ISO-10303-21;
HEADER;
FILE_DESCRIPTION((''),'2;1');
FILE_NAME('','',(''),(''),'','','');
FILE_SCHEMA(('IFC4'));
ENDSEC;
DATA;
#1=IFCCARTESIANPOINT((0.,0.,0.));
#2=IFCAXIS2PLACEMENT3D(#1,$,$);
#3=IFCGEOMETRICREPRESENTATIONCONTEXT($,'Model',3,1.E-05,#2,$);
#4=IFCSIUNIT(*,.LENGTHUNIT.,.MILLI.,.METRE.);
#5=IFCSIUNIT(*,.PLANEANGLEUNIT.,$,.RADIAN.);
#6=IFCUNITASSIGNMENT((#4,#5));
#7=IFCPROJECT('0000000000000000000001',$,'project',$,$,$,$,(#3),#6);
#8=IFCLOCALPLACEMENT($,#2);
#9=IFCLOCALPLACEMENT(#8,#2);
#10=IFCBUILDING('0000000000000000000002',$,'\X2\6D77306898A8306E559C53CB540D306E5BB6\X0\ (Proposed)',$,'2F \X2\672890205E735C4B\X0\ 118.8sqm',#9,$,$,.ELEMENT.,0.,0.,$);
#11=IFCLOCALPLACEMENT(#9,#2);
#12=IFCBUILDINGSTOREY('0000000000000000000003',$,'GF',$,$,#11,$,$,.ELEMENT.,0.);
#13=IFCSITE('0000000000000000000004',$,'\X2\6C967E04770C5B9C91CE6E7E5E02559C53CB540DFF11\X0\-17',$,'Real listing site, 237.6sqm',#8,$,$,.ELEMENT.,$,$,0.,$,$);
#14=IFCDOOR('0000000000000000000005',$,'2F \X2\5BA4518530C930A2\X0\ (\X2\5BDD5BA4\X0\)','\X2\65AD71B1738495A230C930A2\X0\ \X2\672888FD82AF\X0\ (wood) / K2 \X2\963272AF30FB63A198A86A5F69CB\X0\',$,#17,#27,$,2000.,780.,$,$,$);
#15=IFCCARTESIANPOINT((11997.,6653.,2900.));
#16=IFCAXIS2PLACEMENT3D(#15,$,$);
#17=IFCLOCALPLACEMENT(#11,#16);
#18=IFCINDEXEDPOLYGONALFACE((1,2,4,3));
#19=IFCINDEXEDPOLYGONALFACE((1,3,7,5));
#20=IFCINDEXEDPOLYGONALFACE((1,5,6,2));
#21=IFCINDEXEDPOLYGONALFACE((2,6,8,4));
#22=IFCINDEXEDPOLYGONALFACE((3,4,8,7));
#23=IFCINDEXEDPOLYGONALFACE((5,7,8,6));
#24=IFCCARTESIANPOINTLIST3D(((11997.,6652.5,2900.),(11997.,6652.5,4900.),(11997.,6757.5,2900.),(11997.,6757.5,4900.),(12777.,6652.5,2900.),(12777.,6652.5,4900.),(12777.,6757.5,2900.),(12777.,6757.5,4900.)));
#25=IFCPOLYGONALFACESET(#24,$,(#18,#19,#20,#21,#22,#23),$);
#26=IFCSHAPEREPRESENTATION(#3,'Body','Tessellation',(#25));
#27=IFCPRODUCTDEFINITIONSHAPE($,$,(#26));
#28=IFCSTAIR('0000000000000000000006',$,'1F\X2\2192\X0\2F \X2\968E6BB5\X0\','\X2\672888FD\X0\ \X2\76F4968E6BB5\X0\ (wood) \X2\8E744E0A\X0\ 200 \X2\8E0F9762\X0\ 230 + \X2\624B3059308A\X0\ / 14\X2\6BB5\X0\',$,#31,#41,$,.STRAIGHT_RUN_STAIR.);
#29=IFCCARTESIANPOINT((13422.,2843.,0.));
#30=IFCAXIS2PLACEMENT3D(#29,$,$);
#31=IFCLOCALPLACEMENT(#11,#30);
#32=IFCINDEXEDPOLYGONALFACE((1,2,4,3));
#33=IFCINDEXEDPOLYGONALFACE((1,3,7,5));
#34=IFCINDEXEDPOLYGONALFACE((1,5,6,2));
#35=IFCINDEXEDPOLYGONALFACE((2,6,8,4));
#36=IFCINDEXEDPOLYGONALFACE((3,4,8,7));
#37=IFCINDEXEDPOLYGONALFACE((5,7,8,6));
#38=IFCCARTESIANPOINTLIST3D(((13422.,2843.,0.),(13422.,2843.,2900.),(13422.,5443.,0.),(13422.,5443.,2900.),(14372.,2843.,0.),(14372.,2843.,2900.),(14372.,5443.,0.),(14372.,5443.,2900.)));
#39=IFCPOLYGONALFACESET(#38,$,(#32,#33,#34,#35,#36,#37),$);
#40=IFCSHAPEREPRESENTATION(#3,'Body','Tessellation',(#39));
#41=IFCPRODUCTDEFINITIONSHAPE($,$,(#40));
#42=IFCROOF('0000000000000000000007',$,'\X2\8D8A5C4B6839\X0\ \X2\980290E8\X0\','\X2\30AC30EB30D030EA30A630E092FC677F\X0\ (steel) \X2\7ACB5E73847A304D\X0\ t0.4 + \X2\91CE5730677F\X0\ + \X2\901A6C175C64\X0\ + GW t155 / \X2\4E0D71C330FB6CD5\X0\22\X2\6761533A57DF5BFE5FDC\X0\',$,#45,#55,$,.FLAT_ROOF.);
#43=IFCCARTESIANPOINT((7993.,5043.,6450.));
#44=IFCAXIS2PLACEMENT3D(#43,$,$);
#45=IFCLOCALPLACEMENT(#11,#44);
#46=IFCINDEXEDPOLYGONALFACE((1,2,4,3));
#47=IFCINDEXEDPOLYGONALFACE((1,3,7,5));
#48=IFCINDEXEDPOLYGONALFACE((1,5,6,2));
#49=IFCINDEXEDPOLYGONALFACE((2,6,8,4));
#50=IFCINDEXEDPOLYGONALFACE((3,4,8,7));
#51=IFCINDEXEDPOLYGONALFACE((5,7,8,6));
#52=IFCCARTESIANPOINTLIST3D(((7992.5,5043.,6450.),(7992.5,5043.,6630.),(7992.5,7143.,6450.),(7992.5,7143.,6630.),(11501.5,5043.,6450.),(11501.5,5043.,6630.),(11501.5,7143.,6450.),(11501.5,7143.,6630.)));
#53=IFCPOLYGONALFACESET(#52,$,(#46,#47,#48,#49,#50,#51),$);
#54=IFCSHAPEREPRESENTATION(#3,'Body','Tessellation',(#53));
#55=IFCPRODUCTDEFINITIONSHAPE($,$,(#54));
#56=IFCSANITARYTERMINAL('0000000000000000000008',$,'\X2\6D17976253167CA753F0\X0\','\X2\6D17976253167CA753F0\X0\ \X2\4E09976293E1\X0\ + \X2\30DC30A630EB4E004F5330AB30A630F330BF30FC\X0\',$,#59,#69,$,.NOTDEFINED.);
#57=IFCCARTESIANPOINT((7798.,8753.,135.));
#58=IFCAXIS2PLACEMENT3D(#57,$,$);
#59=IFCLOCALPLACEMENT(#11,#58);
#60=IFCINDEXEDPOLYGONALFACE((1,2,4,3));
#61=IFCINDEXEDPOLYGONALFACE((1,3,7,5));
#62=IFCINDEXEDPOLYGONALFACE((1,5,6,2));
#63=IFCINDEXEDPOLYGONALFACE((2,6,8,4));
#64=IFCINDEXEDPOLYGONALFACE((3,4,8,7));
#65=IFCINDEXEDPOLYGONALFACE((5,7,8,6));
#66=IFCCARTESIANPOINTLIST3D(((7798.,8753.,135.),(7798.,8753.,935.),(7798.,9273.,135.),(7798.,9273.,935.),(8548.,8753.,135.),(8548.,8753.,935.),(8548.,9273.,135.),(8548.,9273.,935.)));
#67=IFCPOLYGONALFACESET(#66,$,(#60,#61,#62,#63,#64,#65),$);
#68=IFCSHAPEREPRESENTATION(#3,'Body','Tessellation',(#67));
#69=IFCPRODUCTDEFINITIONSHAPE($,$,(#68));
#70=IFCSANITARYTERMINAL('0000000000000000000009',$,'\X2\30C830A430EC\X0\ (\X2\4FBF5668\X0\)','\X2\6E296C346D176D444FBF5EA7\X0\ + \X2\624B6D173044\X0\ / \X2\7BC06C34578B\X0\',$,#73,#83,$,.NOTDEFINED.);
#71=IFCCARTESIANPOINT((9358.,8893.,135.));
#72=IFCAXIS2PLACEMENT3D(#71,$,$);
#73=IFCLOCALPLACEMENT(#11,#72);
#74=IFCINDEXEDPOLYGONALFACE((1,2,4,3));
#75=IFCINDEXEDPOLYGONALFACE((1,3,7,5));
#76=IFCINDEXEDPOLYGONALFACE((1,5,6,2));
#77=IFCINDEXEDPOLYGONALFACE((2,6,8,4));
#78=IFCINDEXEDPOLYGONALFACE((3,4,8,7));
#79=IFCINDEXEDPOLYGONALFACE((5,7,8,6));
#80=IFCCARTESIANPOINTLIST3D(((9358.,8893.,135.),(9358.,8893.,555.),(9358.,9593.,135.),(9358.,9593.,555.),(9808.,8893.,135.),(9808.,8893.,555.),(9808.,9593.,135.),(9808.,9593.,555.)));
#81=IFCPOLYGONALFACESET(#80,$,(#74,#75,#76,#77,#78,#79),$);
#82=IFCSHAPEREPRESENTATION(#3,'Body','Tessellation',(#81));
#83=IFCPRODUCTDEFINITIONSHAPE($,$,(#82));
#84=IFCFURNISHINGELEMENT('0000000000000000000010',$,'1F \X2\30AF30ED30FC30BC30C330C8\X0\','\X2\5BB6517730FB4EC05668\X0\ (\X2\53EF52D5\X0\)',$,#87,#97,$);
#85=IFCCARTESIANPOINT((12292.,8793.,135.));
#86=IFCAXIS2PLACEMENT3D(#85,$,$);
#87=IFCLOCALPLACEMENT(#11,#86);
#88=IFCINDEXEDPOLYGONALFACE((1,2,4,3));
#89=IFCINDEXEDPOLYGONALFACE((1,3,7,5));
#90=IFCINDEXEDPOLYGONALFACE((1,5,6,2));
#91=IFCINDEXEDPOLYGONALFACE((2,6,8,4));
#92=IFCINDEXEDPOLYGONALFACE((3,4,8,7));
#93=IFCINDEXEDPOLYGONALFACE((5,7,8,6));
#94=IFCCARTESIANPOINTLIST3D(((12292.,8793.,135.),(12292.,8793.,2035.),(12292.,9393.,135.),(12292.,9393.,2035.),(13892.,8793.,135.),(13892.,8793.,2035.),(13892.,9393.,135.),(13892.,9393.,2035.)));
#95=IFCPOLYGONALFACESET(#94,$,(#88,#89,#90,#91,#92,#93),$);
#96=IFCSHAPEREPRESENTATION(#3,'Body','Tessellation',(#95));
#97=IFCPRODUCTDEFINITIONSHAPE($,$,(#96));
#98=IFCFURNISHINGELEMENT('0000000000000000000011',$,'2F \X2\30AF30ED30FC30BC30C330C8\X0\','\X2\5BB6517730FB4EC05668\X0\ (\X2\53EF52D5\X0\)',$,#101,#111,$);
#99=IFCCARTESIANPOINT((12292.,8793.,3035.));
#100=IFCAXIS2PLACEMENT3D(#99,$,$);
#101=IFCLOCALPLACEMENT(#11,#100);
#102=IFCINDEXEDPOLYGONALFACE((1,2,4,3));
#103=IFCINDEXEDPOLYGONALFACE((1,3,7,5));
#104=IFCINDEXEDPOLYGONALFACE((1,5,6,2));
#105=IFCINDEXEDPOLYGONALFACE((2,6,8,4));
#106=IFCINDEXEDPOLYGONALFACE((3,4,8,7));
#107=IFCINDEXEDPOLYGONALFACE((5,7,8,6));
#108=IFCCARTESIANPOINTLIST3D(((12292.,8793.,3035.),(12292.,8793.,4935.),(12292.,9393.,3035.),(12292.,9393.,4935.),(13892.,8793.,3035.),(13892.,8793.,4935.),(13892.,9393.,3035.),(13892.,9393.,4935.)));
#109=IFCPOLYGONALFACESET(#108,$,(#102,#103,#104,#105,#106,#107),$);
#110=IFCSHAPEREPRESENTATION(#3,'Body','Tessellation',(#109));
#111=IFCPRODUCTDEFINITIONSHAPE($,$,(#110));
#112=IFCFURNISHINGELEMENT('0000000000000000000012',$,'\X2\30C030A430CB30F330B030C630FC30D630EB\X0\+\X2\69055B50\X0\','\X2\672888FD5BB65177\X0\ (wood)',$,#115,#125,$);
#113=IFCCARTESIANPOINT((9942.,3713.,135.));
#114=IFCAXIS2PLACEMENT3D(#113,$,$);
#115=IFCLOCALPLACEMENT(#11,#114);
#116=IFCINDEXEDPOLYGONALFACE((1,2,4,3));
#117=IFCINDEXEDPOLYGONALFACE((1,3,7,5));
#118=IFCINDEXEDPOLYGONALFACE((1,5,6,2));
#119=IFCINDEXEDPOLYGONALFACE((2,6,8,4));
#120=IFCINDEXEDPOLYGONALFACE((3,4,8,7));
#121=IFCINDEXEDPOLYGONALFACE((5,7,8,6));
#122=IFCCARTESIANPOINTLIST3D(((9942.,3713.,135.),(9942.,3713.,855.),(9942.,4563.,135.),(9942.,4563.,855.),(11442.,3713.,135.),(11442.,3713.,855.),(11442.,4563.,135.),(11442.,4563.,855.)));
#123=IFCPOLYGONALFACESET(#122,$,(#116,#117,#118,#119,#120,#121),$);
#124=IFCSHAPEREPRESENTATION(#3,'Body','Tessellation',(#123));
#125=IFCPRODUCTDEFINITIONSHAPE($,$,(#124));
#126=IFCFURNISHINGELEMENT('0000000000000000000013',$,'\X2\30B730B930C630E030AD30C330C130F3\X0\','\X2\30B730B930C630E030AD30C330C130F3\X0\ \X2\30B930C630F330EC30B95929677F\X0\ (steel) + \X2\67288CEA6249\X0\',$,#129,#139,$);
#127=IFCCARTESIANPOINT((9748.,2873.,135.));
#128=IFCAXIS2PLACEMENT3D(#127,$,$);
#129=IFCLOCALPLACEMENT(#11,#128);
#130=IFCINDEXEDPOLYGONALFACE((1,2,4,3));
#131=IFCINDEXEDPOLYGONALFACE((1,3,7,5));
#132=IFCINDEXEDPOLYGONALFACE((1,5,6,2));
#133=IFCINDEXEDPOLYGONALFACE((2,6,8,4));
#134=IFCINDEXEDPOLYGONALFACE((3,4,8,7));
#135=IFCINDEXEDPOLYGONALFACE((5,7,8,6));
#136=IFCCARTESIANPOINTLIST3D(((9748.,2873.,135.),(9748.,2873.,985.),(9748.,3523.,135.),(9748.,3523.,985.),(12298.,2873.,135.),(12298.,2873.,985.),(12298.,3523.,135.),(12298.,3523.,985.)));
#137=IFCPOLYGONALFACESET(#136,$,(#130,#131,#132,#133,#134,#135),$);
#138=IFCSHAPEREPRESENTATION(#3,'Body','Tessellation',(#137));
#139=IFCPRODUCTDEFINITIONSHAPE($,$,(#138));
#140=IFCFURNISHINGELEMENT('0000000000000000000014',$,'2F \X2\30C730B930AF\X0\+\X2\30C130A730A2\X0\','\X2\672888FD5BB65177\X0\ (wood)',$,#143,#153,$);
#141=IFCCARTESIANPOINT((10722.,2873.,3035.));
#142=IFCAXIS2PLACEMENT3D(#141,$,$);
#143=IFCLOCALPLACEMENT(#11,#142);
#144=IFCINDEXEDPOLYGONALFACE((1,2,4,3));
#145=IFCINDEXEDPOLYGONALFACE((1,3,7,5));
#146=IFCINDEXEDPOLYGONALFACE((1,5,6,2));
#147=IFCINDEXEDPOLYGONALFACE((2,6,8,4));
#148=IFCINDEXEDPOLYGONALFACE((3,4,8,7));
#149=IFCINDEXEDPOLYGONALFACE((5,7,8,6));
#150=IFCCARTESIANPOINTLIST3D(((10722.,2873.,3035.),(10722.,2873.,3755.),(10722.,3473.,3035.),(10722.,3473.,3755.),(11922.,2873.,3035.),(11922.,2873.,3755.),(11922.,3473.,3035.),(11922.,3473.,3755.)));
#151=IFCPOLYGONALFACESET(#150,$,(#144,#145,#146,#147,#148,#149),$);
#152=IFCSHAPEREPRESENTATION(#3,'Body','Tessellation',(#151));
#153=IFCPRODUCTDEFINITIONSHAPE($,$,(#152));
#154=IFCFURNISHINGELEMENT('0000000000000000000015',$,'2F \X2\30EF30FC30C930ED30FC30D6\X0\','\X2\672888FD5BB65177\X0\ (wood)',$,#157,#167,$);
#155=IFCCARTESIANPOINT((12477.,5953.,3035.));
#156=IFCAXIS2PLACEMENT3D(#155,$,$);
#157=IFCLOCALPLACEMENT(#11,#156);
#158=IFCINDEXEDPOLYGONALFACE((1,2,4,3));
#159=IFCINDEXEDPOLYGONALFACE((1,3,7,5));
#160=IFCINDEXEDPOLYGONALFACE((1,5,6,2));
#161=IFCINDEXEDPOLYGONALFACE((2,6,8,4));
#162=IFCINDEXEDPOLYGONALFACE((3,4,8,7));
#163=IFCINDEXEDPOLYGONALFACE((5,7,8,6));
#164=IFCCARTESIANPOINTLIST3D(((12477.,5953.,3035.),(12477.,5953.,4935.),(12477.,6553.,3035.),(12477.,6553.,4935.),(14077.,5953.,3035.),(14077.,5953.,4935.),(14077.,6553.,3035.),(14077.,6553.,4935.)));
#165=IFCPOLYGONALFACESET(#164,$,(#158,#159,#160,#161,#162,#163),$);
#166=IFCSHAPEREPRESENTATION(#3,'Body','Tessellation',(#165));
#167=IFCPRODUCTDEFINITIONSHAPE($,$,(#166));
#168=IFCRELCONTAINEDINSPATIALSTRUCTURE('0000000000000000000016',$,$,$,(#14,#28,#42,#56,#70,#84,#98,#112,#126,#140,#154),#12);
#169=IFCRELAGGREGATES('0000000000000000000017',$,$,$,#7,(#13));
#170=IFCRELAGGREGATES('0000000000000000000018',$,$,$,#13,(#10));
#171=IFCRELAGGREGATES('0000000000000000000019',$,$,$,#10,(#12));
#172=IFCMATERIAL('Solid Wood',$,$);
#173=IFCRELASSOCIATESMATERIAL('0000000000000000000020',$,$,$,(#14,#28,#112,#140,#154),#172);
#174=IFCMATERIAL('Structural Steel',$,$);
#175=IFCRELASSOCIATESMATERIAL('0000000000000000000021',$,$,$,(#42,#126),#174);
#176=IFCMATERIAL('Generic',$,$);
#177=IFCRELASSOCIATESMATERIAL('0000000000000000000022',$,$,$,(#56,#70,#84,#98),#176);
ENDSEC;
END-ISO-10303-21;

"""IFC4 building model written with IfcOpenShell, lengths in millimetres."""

from ifc_helpers import new_model, si_unit, frame, frame_2d, origin, place, context, project, spatial, rectangle, extrude, material, element, save


model = new_model("IFC4")

# Units and contexts
model_context = context("Model", 3, precision=1e-05, world=origin())
ifc_project = project(units=[si_unit("LENGTHUNIT", "METRE", prefix="MILLI"), si_unit("PLANEANGLEUNIT", "RADIAN")], contexts=[model_context])

# Site, building, storey
site_placement = place(None, origin())
site = spatial("IfcSite", under=ifc_project, at=site_placement, Name="沖縄県宜野湾市喜友名１-17", ObjectType="Real listing site, 237.6sqm", CompositionType="ELEMENT", RefElevation=0.0)
building_placement = place(site_placement, origin())
building = spatial("IfcBuilding", under=site, at=building_placement, Name="海と風の喜友名の家 (Proposed)", ObjectType="2F 木造平屋 118.8sqm", CompositionType="ELEMENT", ElevationOfRefHeight=0.0, ElevationOfTerrain=0.0)
storey_placement = place(building_placement, origin())
storey = spatial("IfcBuildingStorey", under=building, at=storey_placement, Name="GF", CompositionType="ELEMENT", Elevation=0.0)

# Shared definitions
ifc_material_1 = material(Name="Solid Wood")

# Door
door_1_placement = place(storey_placement, frame((11997.0, 6653.0, 2900.0)))
element("IfcDoor", 1, at=door_1_placement, inside=storey, material=ifc_material_1, Name="2F 室内ドア (寝室)", Description="断熱玄関ドア 木製芯 (wood) / K2 防犯・採風機構", OverallHeight=2000.0, OverallWidth=780.0, context=model_context, shape_type="SweptSolid", body=[
    extrude(rectangle(XDim=780.0, YDim=105.0, at=frame_2d((390.0, 52.0))), frame((11997.0, 6653.0, 2900.0)), (0.0, 0.0, 1.0), 2000.0),
])

# Stair
stair_placement = place(storey_placement, frame((13422.0, 2843.0, 0.0)))
element("IfcStair", 2, at=stair_placement, inside=storey, material=ifc_material_1, Name="1F→2F 階段", Description="木製 直階段 (wood) 蹴上 200 踏面 230 + 手すり / 14段", PredefinedType="STRAIGHT_RUN_STAIR", context=model_context, shape_type="SweptSolid", body=[
    extrude(rectangle(XDim=950.0, YDim=2600.0, at=frame_2d((475.0, 1300.0))), frame((13422.0, 2843.0, 0.0)), (0.0, 0.0, 1.0), 2900.0),
])

# Roof
ifc_material_2 = material(Name="Structural Steel")
roof_placement = place(storey_placement, frame((7993.0, 5043.0, 6450.0)))
element("IfcRoof", 3, at=roof_placement, inside=storey, material=ifc_material_2, Name="越屋根 頂部", Description="ガルバリウム鋼板 (steel) 立平葺き t0.4 + 野地板 + 通気層 + GW t155 / 不燃・法22条区域対応", PredefinedType="FLAT_ROOF", context=model_context, shape_type="SweptSolid", body=[
    extrude(rectangle(XDim=3509.0, YDim=2100.0, at=frame_2d((1754.0, 1050.0))), frame((7993.0, 5043.0, 6450.0)), (0.0, 0.0, 1.0), 180.0),
])

# Sanitary terminals
ifc_material_3 = material(Name="Generic")
sanitary_terminal_1_placement = place(storey_placement, frame((7798.0, 8753.0, 135.0)))
element("IfcSanitaryTerminal", 4, at=sanitary_terminal_1_placement, inside=storey, material=ifc_material_3, Name="洗面化粧台", Description="洗面化粧台 三面鏡 + ボウル一体カウンター", PredefinedType="NOTDEFINED", context=model_context, shape_type="SweptSolid", body=[
    extrude(rectangle(XDim=750.0, YDim=520.0, at=frame_2d((375.0, 260.0))), frame((7798.0, 8753.0, 135.0)), (0.0, 0.0, 1.0), 800.0),
])
sanitary_terminal_2_placement = place(storey_placement, frame((9358.0, 8893.0, 135.0)))
element("IfcSanitaryTerminal", 5, at=sanitary_terminal_2_placement, inside=storey, material=ifc_material_3, Name="トイレ (便器)", Description="温水洗浄便座 + 手洗い / 節水型", PredefinedType="NOTDEFINED", context=model_context, shape_type="SweptSolid", body=[
    extrude(rectangle(XDim=450.0, YDim=700.0, at=frame_2d((225.0, 350.0))), frame((9358.0, 8893.0, 135.0)), (0.0, 0.0, 1.0), 420.0),
])

# Furnishing elements
furnishing_1_placement = place(storey_placement, frame((12292.0, 8793.0, 135.0)))
element("IfcFurnishingElement", 6, at=furnishing_1_placement, inside=storey, material=ifc_material_3, Name="1F クローゼット", Description="家具・什器 (可動)", context=model_context, shape_type="SweptSolid", body=[
    extrude(rectangle(XDim=1600.0, YDim=600.0, at=frame_2d((800.0, 300.0))), frame((12292.0, 8793.0, 135.0)), (0.0, 0.0, 1.0), 1900.0),
])
furnishing_2_placement = place(storey_placement, frame((12292.0, 8793.0, 3035.0)))
element("IfcFurnishingElement", 7, at=furnishing_2_placement, inside=storey, material=ifc_material_3, Name="2F クローゼット", Description="家具・什器 (可動)", context=model_context, shape_type="SweptSolid", body=[
    extrude(rectangle(XDim=1600.0, YDim=600.0, at=frame_2d((800.0, 300.0))), frame((12292.0, 8793.0, 3035.0)), (0.0, 0.0, 1.0), 1900.0),
])
furnishing_3_placement = place(storey_placement, frame((9942.0, 3713.0, 135.0)))
element("IfcFurnishingElement", 8, at=furnishing_3_placement, inside=storey, material=ifc_material_1, Name="ダイニングテーブル+椅子", Description="木製家具 (wood)", context=model_context, shape_type="SweptSolid", body=[
    extrude(rectangle(XDim=1500.0, YDim=850.0, at=frame_2d((750.0, 425.0))), frame((9942.0, 3713.0, 135.0)), (0.0, 0.0, 1.0), 720.0),
])
furnishing_4_placement = place(storey_placement, frame((9748.0, 2873.0, 135.0)))
element("IfcFurnishingElement", 9, at=furnishing_4_placement, inside=storey, material=ifc_material_2, Name="システムキッチン", Description="システムキッチン ステンレス天板 (steel) + 木質扉", context=model_context, shape_type="SweptSolid", body=[
    extrude(rectangle(XDim=2550.0, YDim=650.0, at=frame_2d((1275.0, 325.0))), frame((9748.0, 2873.0, 135.0)), (0.0, 0.0, 1.0), 850.0),
])
furnishing_5_placement = place(storey_placement, frame((10722.0, 2873.0, 3035.0)))
element("IfcFurnishingElement", 10, at=furnishing_5_placement, inside=storey, material=ifc_material_1, Name="2F デスク+チェア", Description="木製家具 (wood)", context=model_context, shape_type="SweptSolid", body=[
    extrude(rectangle(XDim=1200.0, YDim=600.0, at=frame_2d((600.0, 300.0))), frame((10722.0, 2873.0, 3035.0)), (0.0, 0.0, 1.0), 720.0),
])
furnishing_6_placement = place(storey_placement, frame((12477.0, 5953.0, 3035.0)))
element("IfcFurnishingElement", 11, at=furnishing_6_placement, inside=storey, material=ifc_material_1, Name="2F ワードローブ", Description="木製家具 (wood)", context=model_context, shape_type="SweptSolid", body=[
    extrude(rectangle(XDim=1600.0, YDim=600.0, at=frame_2d((800.0, 300.0))), frame((12477.0, 5953.0, 3035.0)), (0.0, 0.0, 1.0), 1900.0),
])

save(model, "model.ifc")
